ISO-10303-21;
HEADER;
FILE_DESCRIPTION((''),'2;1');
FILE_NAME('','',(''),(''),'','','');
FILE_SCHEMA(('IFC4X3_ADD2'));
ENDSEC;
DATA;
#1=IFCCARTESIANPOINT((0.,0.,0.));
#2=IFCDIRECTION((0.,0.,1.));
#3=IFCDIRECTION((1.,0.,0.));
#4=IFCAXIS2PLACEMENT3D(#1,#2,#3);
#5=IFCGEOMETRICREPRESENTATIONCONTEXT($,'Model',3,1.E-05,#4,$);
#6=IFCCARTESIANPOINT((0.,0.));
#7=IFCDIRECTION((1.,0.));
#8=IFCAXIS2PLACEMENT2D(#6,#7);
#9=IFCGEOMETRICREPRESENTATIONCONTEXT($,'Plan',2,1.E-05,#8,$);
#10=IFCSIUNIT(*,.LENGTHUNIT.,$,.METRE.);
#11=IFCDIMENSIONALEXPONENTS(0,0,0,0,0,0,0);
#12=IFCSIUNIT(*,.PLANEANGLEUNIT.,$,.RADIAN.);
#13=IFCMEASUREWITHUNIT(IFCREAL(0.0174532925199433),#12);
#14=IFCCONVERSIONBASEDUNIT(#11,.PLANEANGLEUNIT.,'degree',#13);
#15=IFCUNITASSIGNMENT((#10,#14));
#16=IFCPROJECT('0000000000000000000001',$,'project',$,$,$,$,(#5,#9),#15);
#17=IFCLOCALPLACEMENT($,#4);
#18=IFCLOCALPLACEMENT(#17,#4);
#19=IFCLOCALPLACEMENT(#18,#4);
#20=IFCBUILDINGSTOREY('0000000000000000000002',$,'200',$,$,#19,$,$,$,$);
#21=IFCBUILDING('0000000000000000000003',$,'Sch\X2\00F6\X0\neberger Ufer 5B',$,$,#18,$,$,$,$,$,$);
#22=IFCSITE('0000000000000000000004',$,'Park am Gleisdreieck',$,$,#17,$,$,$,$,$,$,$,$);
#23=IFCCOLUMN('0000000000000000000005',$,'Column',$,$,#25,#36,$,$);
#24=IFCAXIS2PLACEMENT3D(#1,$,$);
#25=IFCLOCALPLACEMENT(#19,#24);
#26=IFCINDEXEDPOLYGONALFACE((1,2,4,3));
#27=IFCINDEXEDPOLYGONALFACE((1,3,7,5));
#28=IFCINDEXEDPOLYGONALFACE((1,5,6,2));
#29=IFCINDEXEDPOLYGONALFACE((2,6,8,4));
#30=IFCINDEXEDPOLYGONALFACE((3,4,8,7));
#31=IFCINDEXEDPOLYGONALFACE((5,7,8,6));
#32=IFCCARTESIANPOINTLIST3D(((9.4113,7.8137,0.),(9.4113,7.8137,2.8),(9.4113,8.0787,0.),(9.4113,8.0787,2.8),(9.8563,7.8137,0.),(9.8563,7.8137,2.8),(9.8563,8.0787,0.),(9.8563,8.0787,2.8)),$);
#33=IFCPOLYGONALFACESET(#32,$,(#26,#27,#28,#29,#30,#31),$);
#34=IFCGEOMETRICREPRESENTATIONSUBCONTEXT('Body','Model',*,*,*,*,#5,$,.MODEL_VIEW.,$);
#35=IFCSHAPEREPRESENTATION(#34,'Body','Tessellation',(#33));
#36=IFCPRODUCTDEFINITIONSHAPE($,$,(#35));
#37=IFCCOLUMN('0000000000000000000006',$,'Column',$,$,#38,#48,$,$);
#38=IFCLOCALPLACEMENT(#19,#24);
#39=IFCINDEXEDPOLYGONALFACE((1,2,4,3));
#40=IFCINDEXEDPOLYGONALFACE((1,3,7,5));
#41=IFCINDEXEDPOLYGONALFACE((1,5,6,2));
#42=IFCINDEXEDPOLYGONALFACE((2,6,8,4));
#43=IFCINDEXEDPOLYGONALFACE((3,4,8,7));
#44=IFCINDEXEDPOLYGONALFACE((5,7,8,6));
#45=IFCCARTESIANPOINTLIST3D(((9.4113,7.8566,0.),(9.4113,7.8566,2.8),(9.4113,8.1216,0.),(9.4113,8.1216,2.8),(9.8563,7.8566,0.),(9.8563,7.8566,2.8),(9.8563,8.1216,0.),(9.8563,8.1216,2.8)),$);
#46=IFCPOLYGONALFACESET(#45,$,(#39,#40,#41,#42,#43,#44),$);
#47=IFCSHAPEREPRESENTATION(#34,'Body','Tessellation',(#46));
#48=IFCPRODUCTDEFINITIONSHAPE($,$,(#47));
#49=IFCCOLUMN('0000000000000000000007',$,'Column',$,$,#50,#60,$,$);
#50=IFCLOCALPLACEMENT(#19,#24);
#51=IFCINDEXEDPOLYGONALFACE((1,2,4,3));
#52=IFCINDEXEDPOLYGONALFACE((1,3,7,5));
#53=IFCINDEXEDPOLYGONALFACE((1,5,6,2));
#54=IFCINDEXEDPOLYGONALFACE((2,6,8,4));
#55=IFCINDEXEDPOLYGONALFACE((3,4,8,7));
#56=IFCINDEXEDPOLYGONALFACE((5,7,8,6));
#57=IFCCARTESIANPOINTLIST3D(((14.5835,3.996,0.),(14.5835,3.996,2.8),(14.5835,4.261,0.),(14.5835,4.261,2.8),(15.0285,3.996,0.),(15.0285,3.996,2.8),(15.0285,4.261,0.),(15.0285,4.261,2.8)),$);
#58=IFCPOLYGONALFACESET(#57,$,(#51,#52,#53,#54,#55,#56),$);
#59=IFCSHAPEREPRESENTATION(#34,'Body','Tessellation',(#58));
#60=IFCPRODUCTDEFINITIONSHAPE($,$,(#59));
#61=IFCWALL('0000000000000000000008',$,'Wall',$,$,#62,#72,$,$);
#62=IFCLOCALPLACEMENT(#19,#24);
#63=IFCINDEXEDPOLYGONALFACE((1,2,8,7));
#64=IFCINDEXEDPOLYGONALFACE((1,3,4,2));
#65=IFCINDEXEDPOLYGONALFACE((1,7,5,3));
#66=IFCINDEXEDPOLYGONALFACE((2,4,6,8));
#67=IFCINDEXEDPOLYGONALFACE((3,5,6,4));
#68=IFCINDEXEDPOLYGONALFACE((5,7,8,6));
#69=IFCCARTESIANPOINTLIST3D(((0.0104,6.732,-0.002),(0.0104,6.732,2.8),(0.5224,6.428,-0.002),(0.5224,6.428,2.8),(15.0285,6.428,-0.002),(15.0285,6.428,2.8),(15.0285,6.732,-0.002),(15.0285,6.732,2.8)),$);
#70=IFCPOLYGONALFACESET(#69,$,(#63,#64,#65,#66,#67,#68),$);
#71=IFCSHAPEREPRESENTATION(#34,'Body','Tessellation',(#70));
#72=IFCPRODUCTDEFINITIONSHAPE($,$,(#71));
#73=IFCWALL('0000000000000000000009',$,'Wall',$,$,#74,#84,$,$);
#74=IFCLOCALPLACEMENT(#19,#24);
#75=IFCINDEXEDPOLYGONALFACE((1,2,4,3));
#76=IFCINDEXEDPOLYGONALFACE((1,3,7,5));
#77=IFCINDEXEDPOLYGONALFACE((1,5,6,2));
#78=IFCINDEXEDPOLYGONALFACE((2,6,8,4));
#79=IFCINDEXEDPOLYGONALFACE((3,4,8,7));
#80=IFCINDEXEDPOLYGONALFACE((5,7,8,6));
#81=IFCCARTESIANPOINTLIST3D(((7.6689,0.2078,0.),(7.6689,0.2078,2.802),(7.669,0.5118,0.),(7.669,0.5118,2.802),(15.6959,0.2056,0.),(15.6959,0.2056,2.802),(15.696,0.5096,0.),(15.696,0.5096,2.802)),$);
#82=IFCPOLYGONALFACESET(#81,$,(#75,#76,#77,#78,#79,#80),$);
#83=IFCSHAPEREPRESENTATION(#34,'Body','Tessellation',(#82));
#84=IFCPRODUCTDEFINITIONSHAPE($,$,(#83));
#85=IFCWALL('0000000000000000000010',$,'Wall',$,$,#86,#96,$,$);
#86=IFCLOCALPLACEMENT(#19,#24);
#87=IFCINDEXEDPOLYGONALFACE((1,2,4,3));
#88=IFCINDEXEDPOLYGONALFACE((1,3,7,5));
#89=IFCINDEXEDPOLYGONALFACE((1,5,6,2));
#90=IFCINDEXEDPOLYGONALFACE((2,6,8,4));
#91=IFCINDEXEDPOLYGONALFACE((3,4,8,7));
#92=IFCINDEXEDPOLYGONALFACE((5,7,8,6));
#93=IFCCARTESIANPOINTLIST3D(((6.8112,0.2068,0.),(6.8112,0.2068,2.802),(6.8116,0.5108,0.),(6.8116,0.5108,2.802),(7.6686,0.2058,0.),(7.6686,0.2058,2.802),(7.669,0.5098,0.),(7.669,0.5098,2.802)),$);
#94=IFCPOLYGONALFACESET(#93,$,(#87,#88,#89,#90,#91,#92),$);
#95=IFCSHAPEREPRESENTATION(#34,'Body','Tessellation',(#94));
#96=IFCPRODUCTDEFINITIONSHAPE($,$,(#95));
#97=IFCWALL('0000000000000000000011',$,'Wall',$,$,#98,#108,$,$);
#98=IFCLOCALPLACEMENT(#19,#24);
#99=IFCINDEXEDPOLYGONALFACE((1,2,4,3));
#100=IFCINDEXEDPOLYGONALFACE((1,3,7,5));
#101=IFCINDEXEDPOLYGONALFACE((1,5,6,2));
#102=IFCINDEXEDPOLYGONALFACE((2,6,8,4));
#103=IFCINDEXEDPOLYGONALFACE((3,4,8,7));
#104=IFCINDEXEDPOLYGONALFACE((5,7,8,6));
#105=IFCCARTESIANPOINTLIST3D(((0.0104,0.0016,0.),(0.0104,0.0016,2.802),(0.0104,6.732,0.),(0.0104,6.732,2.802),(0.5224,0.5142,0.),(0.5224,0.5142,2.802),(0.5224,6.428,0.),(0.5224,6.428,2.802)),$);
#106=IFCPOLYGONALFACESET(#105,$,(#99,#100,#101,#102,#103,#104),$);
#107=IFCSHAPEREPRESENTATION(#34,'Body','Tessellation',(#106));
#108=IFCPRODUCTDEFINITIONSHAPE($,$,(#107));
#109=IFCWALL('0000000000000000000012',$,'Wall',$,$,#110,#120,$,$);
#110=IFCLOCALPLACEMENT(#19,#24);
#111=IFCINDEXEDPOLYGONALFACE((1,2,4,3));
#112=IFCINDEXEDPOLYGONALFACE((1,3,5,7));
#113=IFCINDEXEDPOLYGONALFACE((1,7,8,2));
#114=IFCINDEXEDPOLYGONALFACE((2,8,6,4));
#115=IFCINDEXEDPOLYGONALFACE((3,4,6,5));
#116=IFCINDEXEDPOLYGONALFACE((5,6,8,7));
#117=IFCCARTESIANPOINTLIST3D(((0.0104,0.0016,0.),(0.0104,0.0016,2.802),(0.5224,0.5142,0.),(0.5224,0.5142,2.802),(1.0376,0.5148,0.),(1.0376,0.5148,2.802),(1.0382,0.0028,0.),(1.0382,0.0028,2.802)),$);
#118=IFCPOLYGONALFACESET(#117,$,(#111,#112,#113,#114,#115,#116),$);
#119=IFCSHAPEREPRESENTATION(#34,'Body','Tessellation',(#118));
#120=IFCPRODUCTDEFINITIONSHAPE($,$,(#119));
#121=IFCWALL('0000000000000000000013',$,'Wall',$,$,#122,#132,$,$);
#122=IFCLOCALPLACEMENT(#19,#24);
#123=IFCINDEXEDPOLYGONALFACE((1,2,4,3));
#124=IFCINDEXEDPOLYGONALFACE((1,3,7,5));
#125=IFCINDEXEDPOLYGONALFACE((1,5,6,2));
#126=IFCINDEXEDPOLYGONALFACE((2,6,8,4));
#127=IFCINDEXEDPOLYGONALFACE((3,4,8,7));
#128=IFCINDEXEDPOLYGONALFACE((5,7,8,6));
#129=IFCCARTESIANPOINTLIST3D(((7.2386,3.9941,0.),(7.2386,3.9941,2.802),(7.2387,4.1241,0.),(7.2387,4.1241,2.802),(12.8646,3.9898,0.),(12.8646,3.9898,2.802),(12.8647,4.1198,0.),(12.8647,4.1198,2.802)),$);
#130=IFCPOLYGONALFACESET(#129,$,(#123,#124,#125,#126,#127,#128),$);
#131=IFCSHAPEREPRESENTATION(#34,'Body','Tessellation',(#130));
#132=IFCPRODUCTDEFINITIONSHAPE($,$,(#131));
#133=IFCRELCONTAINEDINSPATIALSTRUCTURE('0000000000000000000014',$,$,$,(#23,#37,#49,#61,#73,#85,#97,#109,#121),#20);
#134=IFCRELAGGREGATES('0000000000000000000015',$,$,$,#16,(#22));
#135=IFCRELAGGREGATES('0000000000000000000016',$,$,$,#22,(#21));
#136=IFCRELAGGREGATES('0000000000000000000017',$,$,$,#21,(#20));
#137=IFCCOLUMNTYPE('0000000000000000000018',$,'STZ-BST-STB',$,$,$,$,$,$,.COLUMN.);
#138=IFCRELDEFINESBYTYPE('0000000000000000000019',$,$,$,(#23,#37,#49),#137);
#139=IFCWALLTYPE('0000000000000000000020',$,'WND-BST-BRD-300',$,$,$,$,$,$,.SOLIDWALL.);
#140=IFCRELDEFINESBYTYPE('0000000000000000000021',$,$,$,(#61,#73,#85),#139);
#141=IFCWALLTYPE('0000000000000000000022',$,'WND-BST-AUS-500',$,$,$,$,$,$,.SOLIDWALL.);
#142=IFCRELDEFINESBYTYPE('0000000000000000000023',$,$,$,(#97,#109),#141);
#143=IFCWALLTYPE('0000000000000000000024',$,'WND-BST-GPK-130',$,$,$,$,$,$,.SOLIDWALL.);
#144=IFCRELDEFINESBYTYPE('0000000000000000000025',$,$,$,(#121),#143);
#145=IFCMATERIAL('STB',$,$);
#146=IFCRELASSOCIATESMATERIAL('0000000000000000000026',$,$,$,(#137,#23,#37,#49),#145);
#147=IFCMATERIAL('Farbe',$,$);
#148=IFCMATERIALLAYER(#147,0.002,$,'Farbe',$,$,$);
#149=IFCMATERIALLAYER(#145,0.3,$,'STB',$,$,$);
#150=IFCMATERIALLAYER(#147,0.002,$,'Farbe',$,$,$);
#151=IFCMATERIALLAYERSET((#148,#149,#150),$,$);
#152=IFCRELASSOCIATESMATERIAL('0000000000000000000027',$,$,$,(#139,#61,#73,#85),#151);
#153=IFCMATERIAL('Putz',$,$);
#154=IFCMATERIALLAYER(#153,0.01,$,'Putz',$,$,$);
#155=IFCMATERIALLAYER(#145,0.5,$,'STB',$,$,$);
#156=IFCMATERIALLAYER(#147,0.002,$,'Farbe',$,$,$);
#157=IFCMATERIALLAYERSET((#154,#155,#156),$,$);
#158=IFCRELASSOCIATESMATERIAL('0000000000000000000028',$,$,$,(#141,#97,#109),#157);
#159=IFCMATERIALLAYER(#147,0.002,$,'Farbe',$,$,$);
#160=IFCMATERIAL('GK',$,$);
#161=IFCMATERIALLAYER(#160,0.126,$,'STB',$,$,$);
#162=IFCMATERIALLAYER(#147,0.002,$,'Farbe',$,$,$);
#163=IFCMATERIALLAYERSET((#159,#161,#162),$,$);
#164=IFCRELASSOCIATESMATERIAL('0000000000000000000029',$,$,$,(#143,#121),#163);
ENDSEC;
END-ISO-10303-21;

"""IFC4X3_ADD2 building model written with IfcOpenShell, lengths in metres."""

from ifc_helpers import new_model, entity, si_unit, converted_unit, frame, origin_with_axes, origin_2d_with_axis, place, context, subcontext, project, spatial, line, indexed_curve, rectangle, outline, extrude, material, layer, layer_set, layer_usage, material_profile, profile_set, profile_usage, type_object, element, save


model = new_model("IFC4X3_ADD2")

# Units and contexts
model_context = context("Model", 3, precision=1e-05, world=origin_with_axes())
plan_context = context("Plan", 2, precision=1e-05, world=origin_2d_with_axis())
body_context = subcontext(model_context, "Body", "Model", "MODEL_VIEW")
ifc_project = project(units=[si_unit("LENGTHUNIT", "METRE"), converted_unit("PLANEANGLEUNIT", "degree", entity("IfcReal", 0.0174532925199433), si_unit("PLANEANGLEUNIT", "RADIAN"), dimensions=[0, 0, 0, 0, 0, 0, 0])], contexts=[model_context, plan_context])

# Site, building, storey
site_placement = place(None, origin_with_axes())
site = spatial("IfcSite", under=ifc_project, at=site_placement, Name="Park am Gleisdreieck")
building_placement = place(site_placement, origin_with_axes())
building = spatial("IfcBuilding", under=site, at=building_placement, Name="Schöneberger Ufer 5B")
storey_placement = place(building_placement, origin_with_axes())
storey = spatial("IfcBuildingStorey", under=building, at=storey_placement, Name="200")

# Columns
ifc_material_1 = material(Name="STB")
ifc_material_profile = material_profile(ifc_material_1, rectangle(XDim=0.445, YDim=0.265))
ifc_profile_set = profile_set([ifc_material_profile])
ifc_profile_usage_1 = profile_usage(ifc_profile_set, cardinal=1)
column_type = type_object("IfcColumnType", Name="STZ-BST-STB", PredefinedType="COLUMN", material=ifc_profile_set)
column_1_placement = place(storey_placement, frame((9.8563, 7.8137, 0.0), z_axis=(0.0, 0.0, 1.0), x_axis=(1.0, 0.0, 0.0)))
element("IfcColumn", 1, at=column_1_placement, inside=storey, type_object=column_type, material=ifc_profile_usage_1, Name="Column", context=body_context, shape_type="SweptSolid", body=[
    extrude(rectangle(XDim=0.445, YDim=0.265), frame((-0.2225, 0.1325, 0.0), z_axis=(0.0, 0.0, 1.0), x_axis=(1.0, 0.0, 0.0)), (0.0, 0.0, 1.0), 2.8),
])
ifc_profile_usage_2 = profile_usage(ifc_profile_set, cardinal=1)
column_2_placement = place(storey_placement, frame((9.8563, 7.8566, 0.0), z_axis=(0.0, 0.0, 1.0), x_axis=(1.0, 0.0, 0.0)))
element("IfcColumn", 2, at=column_2_placement, inside=storey, type_object=column_type, material=ifc_profile_usage_2, Name="Column", context=body_context, shape_type="SweptSolid", body=[
    extrude(rectangle(XDim=0.445, YDim=0.265), frame((-0.2225, 0.1325, 0.0), z_axis=(0.0, 0.0, 1.0), x_axis=(1.0, 0.0, 0.0)), (0.0, 0.0, 1.0), 2.8),
])
ifc_profile_usage_3 = profile_usage(ifc_profile_set, cardinal=3)
column_3_placement = place(storey_placement, frame((14.5835, 3.996, 0.0), z_axis=(0.0, 0.0, 1.0), x_axis=(1.0, 0.0, 0.0)))
element("IfcColumn", 3, at=column_3_placement, inside=storey, type_object=column_type, material=ifc_profile_usage_3, Name="Column", context=body_context, shape_type="SweptSolid", body=[
    extrude(rectangle(XDim=0.445, YDim=0.265), frame((0.2225, 0.1325, 0.0), z_axis=(0.0, 0.0, 1.0), x_axis=(1.0, 0.0, 0.0)), (0.0, 0.0, 1.0), 2.8),
])

# Walls
ifc_material_2 = material(Name="Farbe")
ifc_layer_1 = layer(ifc_material_2, 0.002, Name="Farbe")
ifc_layer_2 = layer(ifc_material_1, 0.3, Name="STB")
ifc_layer_3 = layer(ifc_material_2, 0.002, Name="Farbe")
ifc_layer_set_1 = layer_set([ifc_layer_1, ifc_layer_2, ifc_layer_3])
ifc_layer_usage_1 = layer_usage(ifc_layer_set_1, "AXIS2", "POSITIVE", 0.0)
wall_type_1 = type_object("IfcWallType", Name="WND-BST-BRD-300", PredefinedType="SOLIDWALL", material=ifc_layer_set_1)
wall_1_placement = place(storey_placement, frame((15.0285, 6.732, -0.002), z_axis=(0.0, 0.0, 1.0), x_axis=(-1.0, 0.0, 0.0)))
element("IfcWall", 4, at=wall_1_placement, inside=storey, type_object=wall_type_1, material=ifc_layer_usage_1, Name="Wall", context=body_context, shape_type="SweptSolid", body=[
    extrude(outline(indexed_curve([(0.0, 0.0), (0.0, 0.304), (14.5061, 0.304), (15.0181, 0.0)], segments=[line(1, 2, 3, 4, 1)])), origin_with_axes(), (0.0, 0.0, 1.0), 2.802),
])
ifc_layer_usage_2 = layer_usage(ifc_layer_set_1, "AXIS2", "POSITIVE", 0.0)
wall_2_placement = place(storey_placement, frame((7.6689, 0.2078, 0.0), z_axis=(0.0, 0.0, 1.0), x_axis=(1.0, -0.000271, 0.0)))
element("IfcWall", 5, at=wall_2_placement, inside=storey, type_object=wall_type_1, material=ifc_layer_usage_2, Name="Wall", context=body_context, shape_type="SweptSolid", body=[
    extrude(outline(indexed_curve([(0.0, 0.0), (0.0, 0.304), (8.027, 0.304), (8.027, 0.0)], segments=[line(1, 2, 3, 4, 1)])), origin_with_axes(), (0.0, 0.0, 1.0), 2.802),
])
ifc_layer_usage_3 = layer_usage(ifc_layer_set_1, "AXIS2", "POSITIVE", 0.0)
wall_3_placement = place(storey_placement, frame((7.669, 0.5098, 0.0), z_axis=(0.0, 0.0, 1.0), x_axis=(-0.999999, 0.001175, 0.0)))
element("IfcWall", 6, at=wall_3_placement, inside=storey, type_object=wall_type_1, material=ifc_layer_usage_3, Name="Wall", context=body_context, shape_type="SweptSolid", body=[
    extrude(outline(indexed_curve([(0.0, 0.0), (0.0, 0.304), (0.8574, 0.304), (0.8574, 0.0)], segments=[line(1, 2, 3, 4, 1)])), origin_with_axes(), (0.0, 0.0, 1.0), 2.802),
])
ifc_material_3 = material(Name="Putz")
ifc_layer_4 = layer(ifc_material_3, 0.01, Name="Putz")
ifc_layer_5 = layer(ifc_material_1, 0.5, Name="STB")
ifc_layer_6 = layer(ifc_material_2, 0.002, Name="Farbe")
ifc_layer_set_2 = layer_set([ifc_layer_4, ifc_layer_5, ifc_layer_6])
ifc_layer_usage_4 = layer_usage(ifc_layer_set_2, "AXIS2", "POSITIVE", 0.0)
wall_type_2 = type_object("IfcWallType", Name="WND-BST-AUS-500", PredefinedType="SOLIDWALL", material=ifc_layer_set_2)
wall_4_placement = place(storey_placement, frame((0.0104, 6.732, 0.0), z_axis=(0.0, 0.0, 1.0), x_axis=(0.0, -1.0, 0.0)))
element("IfcWall", 7, at=wall_4_placement, inside=storey, type_object=wall_type_2, material=ifc_layer_usage_4, Name="Wall", context=body_context, shape_type="SweptSolid", body=[
    extrude(outline(indexed_curve([(0.0, 0.0), (0.304, 0.512), (6.2178, 0.512), (6.7304, 0.0)], segments=[line(1, 2, 3, 4, 1)])), origin_with_axes(), (0.0, 0.0, 1.0), 2.802),
])
ifc_layer_usage_5 = layer_usage(ifc_layer_set_2, "AXIS2", "POSITIVE", 0.0)
wall_5_placement = place(storey_placement, frame((0.0104, 0.0016, 0.0), z_axis=(0.0, 0.0, 1.0), x_axis=(0.999999, 0.001219, 0.0)))
element("IfcWall", 8, at=wall_5_placement, inside=storey, type_object=wall_type_2, material=ifc_layer_usage_5, Name="Wall", context=body_context, shape_type="SweptSolid", body=[
    extrude(outline(indexed_curve([(0.0, 0.0), (0.5126, 0.512), (1.0278, 0.512), (1.0278, 0.0)], segments=[line(1, 2, 3, 4, 1)])), origin_with_axes(), (0.0, 0.0, 1.0), 2.802),
])
ifc_layer_7 = layer(ifc_material_2, 0.002, Name="Farbe")
ifc_material_4 = material(Name="GK")
ifc_layer_8 = layer(ifc_material_4, 0.126, Name="STB")
ifc_layer_9 = layer(ifc_material_2, 0.002, Name="Farbe")
ifc_layer_set_3 = layer_set([ifc_layer_7, ifc_layer_8, ifc_layer_9])
ifc_layer_usage_6 = layer_usage(ifc_layer_set_3, "AXIS2", "POSITIVE", 0.0)
wall_type_3 = type_object("IfcWallType", Name="WND-BST-GPK-130", PredefinedType="SOLIDWALL", material=ifc_layer_set_3)
wall_6_placement = place(storey_placement, frame((7.2386, 3.9941, 0.0), z_axis=(0.0, 0.0, 1.0), x_axis=(1.0, -0.000771, 0.0)))
element("IfcWall", 9, at=wall_6_placement, inside=storey, type_object=wall_type_3, material=ifc_layer_usage_6, Name="Wall", context=body_context, shape_type="SweptSolid", body=[
    extrude(outline(indexed_curve([(0.0, 0.0), (0.0, 0.13), (5.626, 0.13), (5.626, 0.0)], segments=[line(1, 2, 3, 4, 1)])), origin_with_axes(), (0.0, 0.0, 1.0), 2.802),
])

save(model, "model.ifc")
